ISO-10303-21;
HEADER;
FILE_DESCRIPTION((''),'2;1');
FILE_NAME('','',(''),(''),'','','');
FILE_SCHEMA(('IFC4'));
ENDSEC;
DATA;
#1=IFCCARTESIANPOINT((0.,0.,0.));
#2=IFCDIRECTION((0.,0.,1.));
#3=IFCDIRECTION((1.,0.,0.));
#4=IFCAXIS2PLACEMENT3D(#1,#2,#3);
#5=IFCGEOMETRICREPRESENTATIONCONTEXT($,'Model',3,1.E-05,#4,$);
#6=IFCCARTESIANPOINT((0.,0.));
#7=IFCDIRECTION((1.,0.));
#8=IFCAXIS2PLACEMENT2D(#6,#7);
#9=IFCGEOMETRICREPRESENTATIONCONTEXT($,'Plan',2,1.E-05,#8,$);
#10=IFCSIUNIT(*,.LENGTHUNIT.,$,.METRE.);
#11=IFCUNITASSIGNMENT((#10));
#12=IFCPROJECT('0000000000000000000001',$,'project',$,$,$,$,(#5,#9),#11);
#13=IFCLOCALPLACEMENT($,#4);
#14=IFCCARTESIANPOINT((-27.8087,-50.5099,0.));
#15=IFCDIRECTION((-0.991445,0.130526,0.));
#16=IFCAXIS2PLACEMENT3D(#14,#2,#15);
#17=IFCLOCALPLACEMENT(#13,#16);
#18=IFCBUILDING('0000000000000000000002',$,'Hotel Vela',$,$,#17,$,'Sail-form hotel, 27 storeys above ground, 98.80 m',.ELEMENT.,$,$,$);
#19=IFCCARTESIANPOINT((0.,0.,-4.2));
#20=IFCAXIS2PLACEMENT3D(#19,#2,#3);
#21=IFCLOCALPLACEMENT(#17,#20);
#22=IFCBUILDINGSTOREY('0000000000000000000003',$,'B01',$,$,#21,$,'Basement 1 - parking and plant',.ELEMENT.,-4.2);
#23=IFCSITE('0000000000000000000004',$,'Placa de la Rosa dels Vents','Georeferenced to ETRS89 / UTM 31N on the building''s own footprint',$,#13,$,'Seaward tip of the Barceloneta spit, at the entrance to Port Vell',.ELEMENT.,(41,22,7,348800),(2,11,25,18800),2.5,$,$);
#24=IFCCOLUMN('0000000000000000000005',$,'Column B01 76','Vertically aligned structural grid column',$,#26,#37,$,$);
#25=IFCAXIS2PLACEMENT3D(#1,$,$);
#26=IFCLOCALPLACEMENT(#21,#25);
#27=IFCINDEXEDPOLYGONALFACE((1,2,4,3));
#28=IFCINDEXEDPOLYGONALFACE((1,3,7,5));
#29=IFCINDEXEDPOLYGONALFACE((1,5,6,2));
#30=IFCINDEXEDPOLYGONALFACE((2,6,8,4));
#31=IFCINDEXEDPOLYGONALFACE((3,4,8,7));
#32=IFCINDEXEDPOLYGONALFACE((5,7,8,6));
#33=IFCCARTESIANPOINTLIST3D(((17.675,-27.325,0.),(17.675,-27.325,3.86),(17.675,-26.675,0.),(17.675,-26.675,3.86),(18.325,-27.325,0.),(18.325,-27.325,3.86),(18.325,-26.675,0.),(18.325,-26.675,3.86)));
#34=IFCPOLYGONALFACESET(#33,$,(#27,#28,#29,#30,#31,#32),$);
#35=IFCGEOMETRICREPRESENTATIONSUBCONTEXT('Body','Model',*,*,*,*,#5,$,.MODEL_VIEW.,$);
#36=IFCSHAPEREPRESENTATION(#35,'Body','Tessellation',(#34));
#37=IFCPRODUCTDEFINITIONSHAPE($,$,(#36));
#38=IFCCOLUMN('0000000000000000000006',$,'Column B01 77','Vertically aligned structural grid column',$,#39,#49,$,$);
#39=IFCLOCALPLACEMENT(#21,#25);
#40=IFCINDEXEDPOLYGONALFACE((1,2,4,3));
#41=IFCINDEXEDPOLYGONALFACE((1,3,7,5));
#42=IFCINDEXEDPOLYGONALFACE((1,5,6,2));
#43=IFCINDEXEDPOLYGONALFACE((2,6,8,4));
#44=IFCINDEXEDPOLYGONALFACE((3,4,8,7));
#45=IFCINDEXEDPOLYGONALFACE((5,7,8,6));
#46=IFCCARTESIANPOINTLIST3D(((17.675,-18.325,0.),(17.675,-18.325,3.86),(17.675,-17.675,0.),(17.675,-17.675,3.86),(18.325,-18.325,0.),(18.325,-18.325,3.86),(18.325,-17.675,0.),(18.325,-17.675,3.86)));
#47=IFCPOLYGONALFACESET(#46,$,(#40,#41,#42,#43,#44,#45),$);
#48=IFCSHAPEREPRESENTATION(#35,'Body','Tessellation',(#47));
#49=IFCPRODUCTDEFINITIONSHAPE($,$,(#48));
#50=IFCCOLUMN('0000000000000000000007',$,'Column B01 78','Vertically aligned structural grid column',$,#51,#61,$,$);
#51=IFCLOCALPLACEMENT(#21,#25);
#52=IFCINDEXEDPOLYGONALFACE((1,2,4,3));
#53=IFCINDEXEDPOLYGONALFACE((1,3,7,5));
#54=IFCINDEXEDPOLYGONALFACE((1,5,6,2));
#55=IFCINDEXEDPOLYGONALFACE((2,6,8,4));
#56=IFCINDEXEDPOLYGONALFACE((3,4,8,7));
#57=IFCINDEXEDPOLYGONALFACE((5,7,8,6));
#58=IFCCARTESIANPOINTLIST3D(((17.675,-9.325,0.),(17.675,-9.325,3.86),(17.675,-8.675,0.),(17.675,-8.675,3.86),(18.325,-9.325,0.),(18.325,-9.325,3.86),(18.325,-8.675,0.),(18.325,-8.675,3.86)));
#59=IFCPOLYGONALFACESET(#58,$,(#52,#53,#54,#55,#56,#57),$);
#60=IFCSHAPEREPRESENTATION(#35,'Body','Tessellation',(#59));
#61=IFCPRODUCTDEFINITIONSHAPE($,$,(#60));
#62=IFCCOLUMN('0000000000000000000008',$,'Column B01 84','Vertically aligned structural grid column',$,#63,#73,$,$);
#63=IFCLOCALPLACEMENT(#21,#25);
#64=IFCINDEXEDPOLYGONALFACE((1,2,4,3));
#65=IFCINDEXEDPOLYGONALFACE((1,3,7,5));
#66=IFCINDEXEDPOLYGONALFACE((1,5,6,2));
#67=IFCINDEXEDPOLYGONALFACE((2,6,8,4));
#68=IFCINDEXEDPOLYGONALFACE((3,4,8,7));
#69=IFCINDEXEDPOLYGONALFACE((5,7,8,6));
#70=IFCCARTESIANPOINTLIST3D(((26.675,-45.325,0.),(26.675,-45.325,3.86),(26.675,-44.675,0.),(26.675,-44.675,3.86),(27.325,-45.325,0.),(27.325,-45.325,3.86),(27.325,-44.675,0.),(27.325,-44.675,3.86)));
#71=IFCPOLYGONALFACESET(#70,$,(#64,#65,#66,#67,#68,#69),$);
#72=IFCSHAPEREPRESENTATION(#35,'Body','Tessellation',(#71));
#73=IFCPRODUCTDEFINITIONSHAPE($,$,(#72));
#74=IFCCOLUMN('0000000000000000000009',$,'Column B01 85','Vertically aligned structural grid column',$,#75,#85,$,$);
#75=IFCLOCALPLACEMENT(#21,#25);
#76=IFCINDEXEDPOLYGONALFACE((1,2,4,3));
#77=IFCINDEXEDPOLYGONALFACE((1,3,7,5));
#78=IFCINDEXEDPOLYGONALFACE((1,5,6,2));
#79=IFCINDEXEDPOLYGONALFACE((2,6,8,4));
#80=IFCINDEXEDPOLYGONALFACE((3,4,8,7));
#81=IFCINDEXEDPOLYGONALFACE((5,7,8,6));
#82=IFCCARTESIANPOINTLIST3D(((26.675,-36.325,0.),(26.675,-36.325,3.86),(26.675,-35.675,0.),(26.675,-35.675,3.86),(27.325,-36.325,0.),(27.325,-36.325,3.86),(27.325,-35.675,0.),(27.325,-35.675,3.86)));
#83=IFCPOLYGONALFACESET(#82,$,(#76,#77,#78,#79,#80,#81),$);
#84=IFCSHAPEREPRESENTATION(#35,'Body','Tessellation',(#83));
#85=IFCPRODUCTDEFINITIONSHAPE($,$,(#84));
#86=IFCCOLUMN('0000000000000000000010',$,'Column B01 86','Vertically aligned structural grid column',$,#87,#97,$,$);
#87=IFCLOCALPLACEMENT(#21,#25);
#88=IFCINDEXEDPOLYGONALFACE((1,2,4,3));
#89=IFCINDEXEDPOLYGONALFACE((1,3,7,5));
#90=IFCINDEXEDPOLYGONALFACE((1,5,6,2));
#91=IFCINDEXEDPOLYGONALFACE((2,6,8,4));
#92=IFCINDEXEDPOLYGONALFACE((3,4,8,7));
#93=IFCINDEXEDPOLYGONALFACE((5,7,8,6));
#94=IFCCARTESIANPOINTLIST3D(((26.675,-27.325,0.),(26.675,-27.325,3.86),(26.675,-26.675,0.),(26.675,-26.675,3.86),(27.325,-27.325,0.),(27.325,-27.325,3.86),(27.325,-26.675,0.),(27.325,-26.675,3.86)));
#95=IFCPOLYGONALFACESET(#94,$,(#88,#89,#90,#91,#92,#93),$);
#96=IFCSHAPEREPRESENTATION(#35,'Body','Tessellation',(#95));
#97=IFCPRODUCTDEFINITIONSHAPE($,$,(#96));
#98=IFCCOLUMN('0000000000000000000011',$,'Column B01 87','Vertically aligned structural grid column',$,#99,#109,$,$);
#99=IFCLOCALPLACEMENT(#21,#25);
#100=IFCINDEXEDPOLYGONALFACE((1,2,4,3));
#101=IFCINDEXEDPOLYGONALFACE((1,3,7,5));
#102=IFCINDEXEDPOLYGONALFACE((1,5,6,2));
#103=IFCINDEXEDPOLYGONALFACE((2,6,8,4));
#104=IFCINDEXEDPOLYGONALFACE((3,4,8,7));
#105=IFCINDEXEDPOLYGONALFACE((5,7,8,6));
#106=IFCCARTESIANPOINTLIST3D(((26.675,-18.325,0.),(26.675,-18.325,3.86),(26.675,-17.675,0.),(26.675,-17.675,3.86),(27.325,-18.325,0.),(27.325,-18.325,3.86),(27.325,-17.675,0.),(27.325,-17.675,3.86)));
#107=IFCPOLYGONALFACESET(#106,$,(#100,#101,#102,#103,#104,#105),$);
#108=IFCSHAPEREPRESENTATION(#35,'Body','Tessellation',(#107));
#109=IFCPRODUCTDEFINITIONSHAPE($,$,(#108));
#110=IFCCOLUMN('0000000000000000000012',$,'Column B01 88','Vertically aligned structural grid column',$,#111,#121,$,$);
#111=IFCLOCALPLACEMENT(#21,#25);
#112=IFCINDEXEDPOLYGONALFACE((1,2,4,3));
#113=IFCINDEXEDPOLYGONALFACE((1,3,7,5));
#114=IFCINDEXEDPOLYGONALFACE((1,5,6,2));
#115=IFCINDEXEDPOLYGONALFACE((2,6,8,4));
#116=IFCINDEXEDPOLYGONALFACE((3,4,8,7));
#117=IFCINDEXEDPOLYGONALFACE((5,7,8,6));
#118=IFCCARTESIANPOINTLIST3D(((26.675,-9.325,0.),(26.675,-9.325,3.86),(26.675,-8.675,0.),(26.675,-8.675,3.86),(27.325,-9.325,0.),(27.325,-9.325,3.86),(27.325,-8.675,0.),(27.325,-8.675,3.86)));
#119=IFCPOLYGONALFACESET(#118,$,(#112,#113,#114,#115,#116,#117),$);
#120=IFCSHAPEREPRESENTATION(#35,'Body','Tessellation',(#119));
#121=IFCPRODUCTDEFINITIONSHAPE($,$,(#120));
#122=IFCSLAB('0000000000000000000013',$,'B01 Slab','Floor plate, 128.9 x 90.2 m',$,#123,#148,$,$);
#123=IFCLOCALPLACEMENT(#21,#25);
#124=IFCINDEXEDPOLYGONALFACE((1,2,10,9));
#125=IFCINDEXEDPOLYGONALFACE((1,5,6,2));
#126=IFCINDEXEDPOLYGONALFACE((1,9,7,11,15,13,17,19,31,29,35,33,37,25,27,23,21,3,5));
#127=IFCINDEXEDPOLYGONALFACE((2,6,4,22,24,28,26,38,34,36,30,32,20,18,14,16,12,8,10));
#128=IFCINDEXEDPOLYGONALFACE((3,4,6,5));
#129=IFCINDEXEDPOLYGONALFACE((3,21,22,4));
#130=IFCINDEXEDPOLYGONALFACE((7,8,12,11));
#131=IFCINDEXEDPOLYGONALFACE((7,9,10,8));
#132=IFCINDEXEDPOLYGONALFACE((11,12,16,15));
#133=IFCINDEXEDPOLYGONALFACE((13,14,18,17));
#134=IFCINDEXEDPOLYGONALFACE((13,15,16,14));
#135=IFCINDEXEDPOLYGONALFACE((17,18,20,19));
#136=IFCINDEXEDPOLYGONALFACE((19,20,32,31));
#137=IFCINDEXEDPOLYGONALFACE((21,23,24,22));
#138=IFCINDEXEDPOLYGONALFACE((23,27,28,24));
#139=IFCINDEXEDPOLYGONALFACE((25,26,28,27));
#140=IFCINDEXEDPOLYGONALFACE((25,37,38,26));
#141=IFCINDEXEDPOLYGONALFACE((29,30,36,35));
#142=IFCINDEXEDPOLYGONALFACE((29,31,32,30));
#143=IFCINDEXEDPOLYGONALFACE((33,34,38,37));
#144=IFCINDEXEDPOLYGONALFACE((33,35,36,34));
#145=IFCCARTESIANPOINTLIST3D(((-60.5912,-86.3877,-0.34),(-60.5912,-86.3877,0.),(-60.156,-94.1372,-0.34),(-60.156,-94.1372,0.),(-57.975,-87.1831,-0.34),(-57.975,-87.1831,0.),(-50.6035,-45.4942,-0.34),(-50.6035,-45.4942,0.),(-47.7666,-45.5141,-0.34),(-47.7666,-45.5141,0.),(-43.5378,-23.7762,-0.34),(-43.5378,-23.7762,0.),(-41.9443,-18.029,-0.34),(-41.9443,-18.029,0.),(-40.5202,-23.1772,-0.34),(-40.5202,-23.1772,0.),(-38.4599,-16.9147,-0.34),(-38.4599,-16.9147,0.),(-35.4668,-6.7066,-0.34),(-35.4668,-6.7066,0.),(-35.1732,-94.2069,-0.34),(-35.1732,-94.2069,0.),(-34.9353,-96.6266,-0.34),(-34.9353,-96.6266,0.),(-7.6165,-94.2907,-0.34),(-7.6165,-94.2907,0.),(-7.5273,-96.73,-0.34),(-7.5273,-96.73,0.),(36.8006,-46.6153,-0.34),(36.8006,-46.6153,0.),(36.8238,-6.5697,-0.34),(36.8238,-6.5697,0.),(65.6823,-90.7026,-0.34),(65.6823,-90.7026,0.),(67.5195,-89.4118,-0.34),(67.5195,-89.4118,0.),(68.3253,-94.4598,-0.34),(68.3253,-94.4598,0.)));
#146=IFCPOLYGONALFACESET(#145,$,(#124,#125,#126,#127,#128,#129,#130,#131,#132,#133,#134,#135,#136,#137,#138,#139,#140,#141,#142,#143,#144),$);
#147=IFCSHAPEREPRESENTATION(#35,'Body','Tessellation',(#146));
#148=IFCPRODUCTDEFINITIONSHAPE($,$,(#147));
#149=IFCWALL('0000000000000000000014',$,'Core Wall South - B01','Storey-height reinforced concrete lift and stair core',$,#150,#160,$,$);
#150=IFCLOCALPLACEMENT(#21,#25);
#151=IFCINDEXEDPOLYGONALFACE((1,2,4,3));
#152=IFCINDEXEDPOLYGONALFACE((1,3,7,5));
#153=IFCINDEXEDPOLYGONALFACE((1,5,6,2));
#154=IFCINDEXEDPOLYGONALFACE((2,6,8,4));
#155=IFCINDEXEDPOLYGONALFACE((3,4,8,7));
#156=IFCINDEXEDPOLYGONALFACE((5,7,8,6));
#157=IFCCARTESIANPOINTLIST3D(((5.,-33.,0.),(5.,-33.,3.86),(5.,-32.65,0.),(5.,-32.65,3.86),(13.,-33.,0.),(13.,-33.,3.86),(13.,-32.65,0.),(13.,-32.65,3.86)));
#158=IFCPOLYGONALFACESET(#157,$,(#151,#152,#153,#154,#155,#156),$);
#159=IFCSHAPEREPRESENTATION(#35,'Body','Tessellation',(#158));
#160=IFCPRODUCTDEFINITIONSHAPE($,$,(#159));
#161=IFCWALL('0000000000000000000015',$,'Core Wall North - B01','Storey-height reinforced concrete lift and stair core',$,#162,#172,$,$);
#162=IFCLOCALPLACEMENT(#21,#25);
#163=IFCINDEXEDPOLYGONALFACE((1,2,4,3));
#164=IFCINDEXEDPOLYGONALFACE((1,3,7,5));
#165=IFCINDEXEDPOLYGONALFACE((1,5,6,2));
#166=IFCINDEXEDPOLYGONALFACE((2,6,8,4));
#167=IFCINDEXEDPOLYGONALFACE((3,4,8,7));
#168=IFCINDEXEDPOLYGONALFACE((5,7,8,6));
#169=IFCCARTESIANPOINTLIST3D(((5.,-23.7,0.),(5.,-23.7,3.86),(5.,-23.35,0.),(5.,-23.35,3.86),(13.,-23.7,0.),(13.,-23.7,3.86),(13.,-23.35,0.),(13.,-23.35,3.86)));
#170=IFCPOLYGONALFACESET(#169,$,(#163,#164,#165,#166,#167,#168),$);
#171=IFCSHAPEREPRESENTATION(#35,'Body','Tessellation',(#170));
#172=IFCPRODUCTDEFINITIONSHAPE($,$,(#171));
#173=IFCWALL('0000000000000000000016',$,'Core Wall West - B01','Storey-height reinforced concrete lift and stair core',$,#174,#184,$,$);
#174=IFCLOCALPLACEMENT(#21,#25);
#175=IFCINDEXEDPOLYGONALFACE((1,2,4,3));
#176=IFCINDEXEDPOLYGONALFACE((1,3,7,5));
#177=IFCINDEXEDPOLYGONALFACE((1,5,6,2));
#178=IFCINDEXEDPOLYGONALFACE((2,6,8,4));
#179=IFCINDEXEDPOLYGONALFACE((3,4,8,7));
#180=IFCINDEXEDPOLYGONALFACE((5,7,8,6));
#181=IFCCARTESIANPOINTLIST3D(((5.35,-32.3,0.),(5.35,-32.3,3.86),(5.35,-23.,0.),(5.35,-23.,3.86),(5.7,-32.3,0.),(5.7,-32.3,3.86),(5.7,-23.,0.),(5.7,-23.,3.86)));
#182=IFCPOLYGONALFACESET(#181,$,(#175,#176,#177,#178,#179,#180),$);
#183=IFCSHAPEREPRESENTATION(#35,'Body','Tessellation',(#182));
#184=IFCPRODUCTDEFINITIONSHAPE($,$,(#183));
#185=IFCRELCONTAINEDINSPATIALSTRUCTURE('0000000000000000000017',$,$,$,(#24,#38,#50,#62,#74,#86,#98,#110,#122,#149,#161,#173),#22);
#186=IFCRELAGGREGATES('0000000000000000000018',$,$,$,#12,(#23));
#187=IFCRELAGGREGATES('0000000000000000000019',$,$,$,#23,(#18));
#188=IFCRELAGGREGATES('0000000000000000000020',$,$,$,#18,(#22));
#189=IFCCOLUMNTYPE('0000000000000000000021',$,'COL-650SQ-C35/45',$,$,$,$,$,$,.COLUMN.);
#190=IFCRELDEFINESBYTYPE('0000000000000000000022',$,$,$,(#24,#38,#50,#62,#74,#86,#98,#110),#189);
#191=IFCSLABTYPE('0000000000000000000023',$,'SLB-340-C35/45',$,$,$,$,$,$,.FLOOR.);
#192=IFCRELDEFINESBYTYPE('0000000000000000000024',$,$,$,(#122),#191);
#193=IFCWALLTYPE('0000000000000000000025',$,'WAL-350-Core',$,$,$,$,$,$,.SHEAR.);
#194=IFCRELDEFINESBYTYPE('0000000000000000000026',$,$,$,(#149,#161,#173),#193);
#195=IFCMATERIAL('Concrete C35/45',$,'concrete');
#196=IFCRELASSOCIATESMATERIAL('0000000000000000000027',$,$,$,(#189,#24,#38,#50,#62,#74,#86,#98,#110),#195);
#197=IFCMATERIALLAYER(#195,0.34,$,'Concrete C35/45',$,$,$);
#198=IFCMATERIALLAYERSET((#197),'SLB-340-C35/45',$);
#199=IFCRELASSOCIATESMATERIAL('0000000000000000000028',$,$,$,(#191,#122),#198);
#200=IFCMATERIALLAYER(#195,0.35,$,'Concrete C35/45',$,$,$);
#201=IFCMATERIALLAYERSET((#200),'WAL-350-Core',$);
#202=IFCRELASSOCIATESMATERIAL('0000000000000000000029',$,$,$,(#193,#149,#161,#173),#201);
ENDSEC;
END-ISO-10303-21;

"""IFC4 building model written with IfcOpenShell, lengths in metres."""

from ifc_helpers import new_model, si_unit, frame, origin_with_axes, origin_2d_with_axis, place, context, subcontext, project, spatial, line, indexed_curve, rectangle, outline, extrude, material, layer, layer_set, layer_usage, material_profile, profile_set, profile_usage, type_object, element, save


model = new_model("IFC4")

# Units and contexts
model_context = context("Model", 3, precision=1e-05, world=origin_with_axes())
plan_context = context("Plan", 2, precision=1e-05, world=origin_2d_with_axis())
body_context = subcontext(model_context, "Body", "Model", "MODEL_VIEW")
ifc_project = project(units=[si_unit("LENGTHUNIT", "METRE")], contexts=[model_context, plan_context])

# Site, building, storey
site_placement = place(None, origin_with_axes())
site = spatial("IfcSite", under=ifc_project, at=site_placement, Name="Placa de la Rosa dels Vents", Description="Georeferenced to ETRS89 / UTM 31N on the building's own footprint", LongName="Seaward tip of the Barceloneta spit, at the entrance to Port Vell", CompositionType="ELEMENT", RefLatitude=(41, 22, 7, 348800), RefLongitude=(2, 11, 25, 18800), RefElevation=2.5)
building_placement = place(site_placement, frame((-27.8087, -50.5099, 0.0), z_axis=(0.0, 0.0, 1.0), x_axis=(-0.991445, 0.130526, 0.0)))
building = spatial("IfcBuilding", under=site, at=building_placement, Name="Hotel Vela", LongName="Sail-form hotel, 27 storeys above ground, 98.80 m", CompositionType="ELEMENT")
storey_placement = place(building_placement, frame((0.0, 0.0, -4.2), z_axis=(0.0, 0.0, 1.0), x_axis=(1.0, 0.0, 0.0)))
storey = spatial("IfcBuildingStorey", under=building, at=storey_placement, Name="B01", LongName="Basement 1 - parking and plant", CompositionType="ELEMENT", Elevation=-4.2)

# Columns
ifc_material = material(Name="Concrete C35/45", Category="concrete")
ifc_material_profile = material_profile(ifc_material, rectangle(XDim=0.65, YDim=0.65))
ifc_profile_set = profile_set([ifc_material_profile], Name="COL-650SQ-C35/45")
column_type = type_object("IfcColumnType", Name="COL-650SQ-C35/45", PredefinedType="COLUMN", material=ifc_profile_set)
ifc_profile_usage_1 = profile_usage(ifc_profile_set)
column_1_placement = place(storey_placement, frame((17.675, -27.325, 0.0), z_axis=(0.0, 0.0, 1.0), x_axis=(1.0, 0.0, 0.0)))
element("IfcColumn", 1, at=column_1_placement, inside=storey, type_object=column_type, material=ifc_profile_usage_1, Name="Column B01 76", Description="Vertically aligned structural grid column", context=body_context, shape_type="SweptSolid", body=[
    extrude(outline(indexed_curve([(0.0, 0.0), (0.65, 0.0), (0.65, 0.65), (0.0, 0.65)], segments=[line(1, 2, 3, 4, 1)])), origin_with_axes(), (0.0, 0.0, 1.0), 3.86),
])
ifc_profile_usage_2 = profile_usage(ifc_profile_set)
column_2_placement = place(storey_placement, frame((17.675, -18.325, 0.0), z_axis=(0.0, 0.0, 1.0), x_axis=(1.0, 0.0, 0.0)))
element("IfcColumn", 2, at=column_2_placement, inside=storey, type_object=column_type, material=ifc_profile_usage_2, Name="Column B01 77", Description="Vertically aligned structural grid column", context=body_context, shape_type="SweptSolid", body=[
    extrude(outline(indexed_curve([(0.0, 0.0), (0.65, 0.0), (0.65, 0.65), (0.0, 0.65)], segments=[line(1, 2, 3, 4, 1)])), origin_with_axes(), (0.0, 0.0, 1.0), 3.86),
])
ifc_profile_usage_3 = profile_usage(ifc_profile_set)
column_3_placement = place(storey_placement, frame((17.675, -9.325, 0.0), z_axis=(0.0, 0.0, 1.0), x_axis=(1.0, 0.0, 0.0)))
element("IfcColumn", 3, at=column_3_placement, inside=storey, type_object=column_type, material=ifc_profile_usage_3, Name="Column B01 78", Description="Vertically aligned structural grid column", context=body_context, shape_type="SweptSolid", body=[
    extrude(outline(indexed_curve([(0.0, 0.0), (0.65, 0.0), (0.65, 0.65), (0.0, 0.65)], segments=[line(1, 2, 3, 4, 1)])), origin_with_axes(), (0.0, 0.0, 1.0), 3.86),
])
ifc_profile_usage_4 = profile_usage(ifc_profile_set)
column_4_placement = place(storey_placement, frame((26.675, -45.325, 0.0), z_axis=(0.0, 0.0, 1.0), x_axis=(1.0, 0.0, 0.0)))
element("IfcColumn", 4, at=column_4_placement, inside=storey, type_object=column_type, material=ifc_profile_usage_4, Name="Column B01 84", Description="Vertically aligned structural grid column", context=body_context, shape_type="SweptSolid", body=[
    extrude(outline(indexed_curve([(0.0, 0.0), (0.65, 0.0), (0.65, 0.65), (0.0, 0.65)], segments=[line(1, 2, 3, 4, 1)])), origin_with_axes(), (0.0, 0.0, 1.0), 3.86),
])
ifc_profile_usage_5 = profile_usage(ifc_profile_set)
column_5_placement = place(storey_placement, frame((26.675, -36.325, 0.0), z_axis=(0.0, 0.0, 1.0), x_axis=(1.0, 0.0, 0.0)))
element("IfcColumn", 5, at=column_5_placement, inside=storey, type_object=column_type, material=ifc_profile_usage_5, Name="Column B01 85", Description="Vertically aligned structural grid column", context=body_context, shape_type="SweptSolid", body=[
    extrude(outline(indexed_curve([(0.0, 0.0), (0.65, 0.0), (0.65, 0.65), (0.0, 0.65)], segments=[line(1, 2, 3, 4, 1)])), origin_with_axes(), (0.0, 0.0, 1.0), 3.86),
])
ifc_profile_usage_6 = profile_usage(ifc_profile_set)
column_6_placement = place(storey_placement, frame((26.675, -27.325, 0.0), z_axis=(0.0, 0.0, 1.0), x_axis=(1.0, 0.0, 0.0)))
element("IfcColumn", 6, at=column_6_placement, inside=storey, type_object=column_type, material=ifc_profile_usage_6, Name="Column B01 86", Description="Vertically aligned structural grid column", context=body_context, shape_type="SweptSolid", body=[
    extrude(outline(indexed_curve([(0.0, 0.0), (0.65, 0.0), (0.65, 0.65), (0.0, 0.65)], segments=[line(1, 2, 3, 4, 1)])), origin_with_axes(), (0.0, 0.0, 1.0), 3.86),
])
ifc_profile_usage_7 = profile_usage(ifc_profile_set)
column_7_placement = place(storey_placement, frame((26.675, -18.325, 0.0), z_axis=(0.0, 0.0, 1.0), x_axis=(1.0, 0.0, 0.0)))
element("IfcColumn", 7, at=column_7_placement, inside=storey, type_object=column_type, material=ifc_profile_usage_7, Name="Column B01 87", Description="Vertically aligned structural grid column", context=body_context, shape_type="SweptSolid", body=[
    extrude(outline(indexed_curve([(0.0, 0.0), (0.65, 0.0), (0.65, 0.65), (0.0, 0.65)], segments=[line(1, 2, 3, 4, 1)])), origin_with_axes(), (0.0, 0.0, 1.0), 3.86),
])
ifc_profile_usage_8 = profile_usage(ifc_profile_set)
column_8_placement = place(storey_placement, frame((26.675, -9.325, 0.0), z_axis=(0.0, 0.0, 1.0), x_axis=(1.0, 0.0, 0.0)))
element("IfcColumn", 8, at=column_8_placement, inside=storey, type_object=column_type, material=ifc_profile_usage_8, Name="Column B01 88", Description="Vertically aligned structural grid column", context=body_context, shape_type="SweptSolid", body=[
    extrude(outline(indexed_curve([(0.0, 0.0), (0.65, 0.0), (0.65, 0.65), (0.0, 0.65)], segments=[line(1, 2, 3, 4, 1)])), origin_with_axes(), (0.0, 0.0, 1.0), 3.86),
])

# Slab
ifc_layer_1 = layer(ifc_material, 0.34, Name="Concrete C35/45")
ifc_layer_set_1 = layer_set([ifc_layer_1], Name="SLB-340-C35/45")
ifc_layer_usage_1 = layer_usage(ifc_layer_set_1, "AXIS3", "POSITIVE", 0.0)
slab_type = type_object("IfcSlabType", Name="SLB-340-C35/45", PredefinedType="FLOOR", material=ifc_layer_set_1)
slab_placement = place(storey_placement, frame((0.0, 0.0, -0.34), z_axis=(0.0, 0.0, 1.0), x_axis=(1.0, 0.0, 0.0)))
element("IfcSlab", 9, at=slab_placement, inside=storey, type_object=slab_type, material=ifc_layer_usage_1, Name="B01 Slab", Description="Floor plate, 128.9 x 90.2 m", context=body_context, shape_type="SweptSolid", body=[
    extrude(outline(indexed_curve([(-60.156, -94.1372), (-35.1732, -94.2069), (-34.9353, -96.6266), (-7.5273, -96.73), (-7.6165, -94.2907), (68.3253, -94.4598), (65.6823, -90.7026), (67.5195, -89.4118), (36.8006, -46.6153), (36.8238, -6.5697), (-35.4668, -6.7066), (-38.4599, -16.9147), (-41.9443, -18.029), (-40.5202, -23.1772), (-43.5378, -23.7762), (-50.6035, -45.4942), (-47.7666, -45.5141), (-60.5912, -86.3877), (-57.975, -87.1831)], segments=[line(1, 2, 3, 4, 5, 6, 7, 8, 9, 10, 11, 12, 13, 14, 15, 16, 17, 18, 19, 1)])), origin_with_axes(), (0.0, 0.0, 1.0), 0.34),
])

# Walls
ifc_layer_2 = layer(ifc_material, 0.35, Name="Concrete C35/45")
ifc_layer_set_2 = layer_set([ifc_layer_2], Name="WAL-350-Core")
ifc_layer_usage_2 = layer_usage(ifc_layer_set_2, "AXIS2", "POSITIVE", 0.0)
wall_type = type_object("IfcWallType", Name="WAL-350-Core", PredefinedType="SHEAR", material=ifc_layer_set_2)
wall_1_placement = place(storey_placement, frame((5.0, -33.0, 0.0), z_axis=(0.0, 0.0, 1.0), x_axis=(1.0, 0.0, 0.0)))
element("IfcWall", 10, at=wall_1_placement, inside=storey, type_object=wall_type, material=ifc_layer_usage_2, Name="Core Wall South - B01", Description="Storey-height reinforced concrete lift and stair core", context=body_context, shape_type="SweptSolid", body=[
    extrude(outline(indexed_curve([(0.0, 0.0), (8.0, 0.0), (8.0, 0.35), (0.0, 0.35)], segments=[line(1, 2, 3, 4, 1)])), origin_with_axes(), (0.0, 0.0, 1.0), 3.86),
])
ifc_layer_usage_3 = layer_usage(ifc_layer_set_2, "AXIS2", "POSITIVE", 0.0)
wall_2_placement = place(storey_placement, frame((13.0, -23.35, 0.0), z_axis=(0.0, 0.0, 1.0), x_axis=(-1.0, 0.0, 0.0)))
element("IfcWall", 11, at=wall_2_placement, inside=storey, type_object=wall_type, material=ifc_layer_usage_3, Name="Core Wall North - B01", Description="Storey-height reinforced concrete lift and stair core", context=body_context, shape_type="SweptSolid", body=[
    extrude(outline(indexed_curve([(0.0, 0.0), (8.0, 0.0), (8.0, 0.35), (0.0, 0.35)], segments=[line(1, 2, 3, 4, 1)])), origin_with_axes(), (0.0, 0.0, 1.0), 3.86),
])
ifc_layer_usage_4 = layer_usage(ifc_layer_set_2, "AXIS2", "POSITIVE", 0.0)
wall_3_placement = place(storey_placement, frame((5.35, -23.0, 0.0), z_axis=(0.0, 0.0, 1.0), x_axis=(0.0, -1.0, 0.0)))
element("IfcWall", 12, at=wall_3_placement, inside=storey, type_object=wall_type, material=ifc_layer_usage_4, Name="Core Wall West - B01", Description="Storey-height reinforced concrete lift and stair core", context=body_context, shape_type="SweptSolid", body=[
    extrude(outline(indexed_curve([(0.0, 0.0), (9.3, 0.0), (9.3, 0.35), (0.0, 0.35)], segments=[line(1, 2, 3, 4, 1)])), origin_with_axes(), (0.0, 0.0, 1.0), 3.86),
])

save(model, "model.ifc")
